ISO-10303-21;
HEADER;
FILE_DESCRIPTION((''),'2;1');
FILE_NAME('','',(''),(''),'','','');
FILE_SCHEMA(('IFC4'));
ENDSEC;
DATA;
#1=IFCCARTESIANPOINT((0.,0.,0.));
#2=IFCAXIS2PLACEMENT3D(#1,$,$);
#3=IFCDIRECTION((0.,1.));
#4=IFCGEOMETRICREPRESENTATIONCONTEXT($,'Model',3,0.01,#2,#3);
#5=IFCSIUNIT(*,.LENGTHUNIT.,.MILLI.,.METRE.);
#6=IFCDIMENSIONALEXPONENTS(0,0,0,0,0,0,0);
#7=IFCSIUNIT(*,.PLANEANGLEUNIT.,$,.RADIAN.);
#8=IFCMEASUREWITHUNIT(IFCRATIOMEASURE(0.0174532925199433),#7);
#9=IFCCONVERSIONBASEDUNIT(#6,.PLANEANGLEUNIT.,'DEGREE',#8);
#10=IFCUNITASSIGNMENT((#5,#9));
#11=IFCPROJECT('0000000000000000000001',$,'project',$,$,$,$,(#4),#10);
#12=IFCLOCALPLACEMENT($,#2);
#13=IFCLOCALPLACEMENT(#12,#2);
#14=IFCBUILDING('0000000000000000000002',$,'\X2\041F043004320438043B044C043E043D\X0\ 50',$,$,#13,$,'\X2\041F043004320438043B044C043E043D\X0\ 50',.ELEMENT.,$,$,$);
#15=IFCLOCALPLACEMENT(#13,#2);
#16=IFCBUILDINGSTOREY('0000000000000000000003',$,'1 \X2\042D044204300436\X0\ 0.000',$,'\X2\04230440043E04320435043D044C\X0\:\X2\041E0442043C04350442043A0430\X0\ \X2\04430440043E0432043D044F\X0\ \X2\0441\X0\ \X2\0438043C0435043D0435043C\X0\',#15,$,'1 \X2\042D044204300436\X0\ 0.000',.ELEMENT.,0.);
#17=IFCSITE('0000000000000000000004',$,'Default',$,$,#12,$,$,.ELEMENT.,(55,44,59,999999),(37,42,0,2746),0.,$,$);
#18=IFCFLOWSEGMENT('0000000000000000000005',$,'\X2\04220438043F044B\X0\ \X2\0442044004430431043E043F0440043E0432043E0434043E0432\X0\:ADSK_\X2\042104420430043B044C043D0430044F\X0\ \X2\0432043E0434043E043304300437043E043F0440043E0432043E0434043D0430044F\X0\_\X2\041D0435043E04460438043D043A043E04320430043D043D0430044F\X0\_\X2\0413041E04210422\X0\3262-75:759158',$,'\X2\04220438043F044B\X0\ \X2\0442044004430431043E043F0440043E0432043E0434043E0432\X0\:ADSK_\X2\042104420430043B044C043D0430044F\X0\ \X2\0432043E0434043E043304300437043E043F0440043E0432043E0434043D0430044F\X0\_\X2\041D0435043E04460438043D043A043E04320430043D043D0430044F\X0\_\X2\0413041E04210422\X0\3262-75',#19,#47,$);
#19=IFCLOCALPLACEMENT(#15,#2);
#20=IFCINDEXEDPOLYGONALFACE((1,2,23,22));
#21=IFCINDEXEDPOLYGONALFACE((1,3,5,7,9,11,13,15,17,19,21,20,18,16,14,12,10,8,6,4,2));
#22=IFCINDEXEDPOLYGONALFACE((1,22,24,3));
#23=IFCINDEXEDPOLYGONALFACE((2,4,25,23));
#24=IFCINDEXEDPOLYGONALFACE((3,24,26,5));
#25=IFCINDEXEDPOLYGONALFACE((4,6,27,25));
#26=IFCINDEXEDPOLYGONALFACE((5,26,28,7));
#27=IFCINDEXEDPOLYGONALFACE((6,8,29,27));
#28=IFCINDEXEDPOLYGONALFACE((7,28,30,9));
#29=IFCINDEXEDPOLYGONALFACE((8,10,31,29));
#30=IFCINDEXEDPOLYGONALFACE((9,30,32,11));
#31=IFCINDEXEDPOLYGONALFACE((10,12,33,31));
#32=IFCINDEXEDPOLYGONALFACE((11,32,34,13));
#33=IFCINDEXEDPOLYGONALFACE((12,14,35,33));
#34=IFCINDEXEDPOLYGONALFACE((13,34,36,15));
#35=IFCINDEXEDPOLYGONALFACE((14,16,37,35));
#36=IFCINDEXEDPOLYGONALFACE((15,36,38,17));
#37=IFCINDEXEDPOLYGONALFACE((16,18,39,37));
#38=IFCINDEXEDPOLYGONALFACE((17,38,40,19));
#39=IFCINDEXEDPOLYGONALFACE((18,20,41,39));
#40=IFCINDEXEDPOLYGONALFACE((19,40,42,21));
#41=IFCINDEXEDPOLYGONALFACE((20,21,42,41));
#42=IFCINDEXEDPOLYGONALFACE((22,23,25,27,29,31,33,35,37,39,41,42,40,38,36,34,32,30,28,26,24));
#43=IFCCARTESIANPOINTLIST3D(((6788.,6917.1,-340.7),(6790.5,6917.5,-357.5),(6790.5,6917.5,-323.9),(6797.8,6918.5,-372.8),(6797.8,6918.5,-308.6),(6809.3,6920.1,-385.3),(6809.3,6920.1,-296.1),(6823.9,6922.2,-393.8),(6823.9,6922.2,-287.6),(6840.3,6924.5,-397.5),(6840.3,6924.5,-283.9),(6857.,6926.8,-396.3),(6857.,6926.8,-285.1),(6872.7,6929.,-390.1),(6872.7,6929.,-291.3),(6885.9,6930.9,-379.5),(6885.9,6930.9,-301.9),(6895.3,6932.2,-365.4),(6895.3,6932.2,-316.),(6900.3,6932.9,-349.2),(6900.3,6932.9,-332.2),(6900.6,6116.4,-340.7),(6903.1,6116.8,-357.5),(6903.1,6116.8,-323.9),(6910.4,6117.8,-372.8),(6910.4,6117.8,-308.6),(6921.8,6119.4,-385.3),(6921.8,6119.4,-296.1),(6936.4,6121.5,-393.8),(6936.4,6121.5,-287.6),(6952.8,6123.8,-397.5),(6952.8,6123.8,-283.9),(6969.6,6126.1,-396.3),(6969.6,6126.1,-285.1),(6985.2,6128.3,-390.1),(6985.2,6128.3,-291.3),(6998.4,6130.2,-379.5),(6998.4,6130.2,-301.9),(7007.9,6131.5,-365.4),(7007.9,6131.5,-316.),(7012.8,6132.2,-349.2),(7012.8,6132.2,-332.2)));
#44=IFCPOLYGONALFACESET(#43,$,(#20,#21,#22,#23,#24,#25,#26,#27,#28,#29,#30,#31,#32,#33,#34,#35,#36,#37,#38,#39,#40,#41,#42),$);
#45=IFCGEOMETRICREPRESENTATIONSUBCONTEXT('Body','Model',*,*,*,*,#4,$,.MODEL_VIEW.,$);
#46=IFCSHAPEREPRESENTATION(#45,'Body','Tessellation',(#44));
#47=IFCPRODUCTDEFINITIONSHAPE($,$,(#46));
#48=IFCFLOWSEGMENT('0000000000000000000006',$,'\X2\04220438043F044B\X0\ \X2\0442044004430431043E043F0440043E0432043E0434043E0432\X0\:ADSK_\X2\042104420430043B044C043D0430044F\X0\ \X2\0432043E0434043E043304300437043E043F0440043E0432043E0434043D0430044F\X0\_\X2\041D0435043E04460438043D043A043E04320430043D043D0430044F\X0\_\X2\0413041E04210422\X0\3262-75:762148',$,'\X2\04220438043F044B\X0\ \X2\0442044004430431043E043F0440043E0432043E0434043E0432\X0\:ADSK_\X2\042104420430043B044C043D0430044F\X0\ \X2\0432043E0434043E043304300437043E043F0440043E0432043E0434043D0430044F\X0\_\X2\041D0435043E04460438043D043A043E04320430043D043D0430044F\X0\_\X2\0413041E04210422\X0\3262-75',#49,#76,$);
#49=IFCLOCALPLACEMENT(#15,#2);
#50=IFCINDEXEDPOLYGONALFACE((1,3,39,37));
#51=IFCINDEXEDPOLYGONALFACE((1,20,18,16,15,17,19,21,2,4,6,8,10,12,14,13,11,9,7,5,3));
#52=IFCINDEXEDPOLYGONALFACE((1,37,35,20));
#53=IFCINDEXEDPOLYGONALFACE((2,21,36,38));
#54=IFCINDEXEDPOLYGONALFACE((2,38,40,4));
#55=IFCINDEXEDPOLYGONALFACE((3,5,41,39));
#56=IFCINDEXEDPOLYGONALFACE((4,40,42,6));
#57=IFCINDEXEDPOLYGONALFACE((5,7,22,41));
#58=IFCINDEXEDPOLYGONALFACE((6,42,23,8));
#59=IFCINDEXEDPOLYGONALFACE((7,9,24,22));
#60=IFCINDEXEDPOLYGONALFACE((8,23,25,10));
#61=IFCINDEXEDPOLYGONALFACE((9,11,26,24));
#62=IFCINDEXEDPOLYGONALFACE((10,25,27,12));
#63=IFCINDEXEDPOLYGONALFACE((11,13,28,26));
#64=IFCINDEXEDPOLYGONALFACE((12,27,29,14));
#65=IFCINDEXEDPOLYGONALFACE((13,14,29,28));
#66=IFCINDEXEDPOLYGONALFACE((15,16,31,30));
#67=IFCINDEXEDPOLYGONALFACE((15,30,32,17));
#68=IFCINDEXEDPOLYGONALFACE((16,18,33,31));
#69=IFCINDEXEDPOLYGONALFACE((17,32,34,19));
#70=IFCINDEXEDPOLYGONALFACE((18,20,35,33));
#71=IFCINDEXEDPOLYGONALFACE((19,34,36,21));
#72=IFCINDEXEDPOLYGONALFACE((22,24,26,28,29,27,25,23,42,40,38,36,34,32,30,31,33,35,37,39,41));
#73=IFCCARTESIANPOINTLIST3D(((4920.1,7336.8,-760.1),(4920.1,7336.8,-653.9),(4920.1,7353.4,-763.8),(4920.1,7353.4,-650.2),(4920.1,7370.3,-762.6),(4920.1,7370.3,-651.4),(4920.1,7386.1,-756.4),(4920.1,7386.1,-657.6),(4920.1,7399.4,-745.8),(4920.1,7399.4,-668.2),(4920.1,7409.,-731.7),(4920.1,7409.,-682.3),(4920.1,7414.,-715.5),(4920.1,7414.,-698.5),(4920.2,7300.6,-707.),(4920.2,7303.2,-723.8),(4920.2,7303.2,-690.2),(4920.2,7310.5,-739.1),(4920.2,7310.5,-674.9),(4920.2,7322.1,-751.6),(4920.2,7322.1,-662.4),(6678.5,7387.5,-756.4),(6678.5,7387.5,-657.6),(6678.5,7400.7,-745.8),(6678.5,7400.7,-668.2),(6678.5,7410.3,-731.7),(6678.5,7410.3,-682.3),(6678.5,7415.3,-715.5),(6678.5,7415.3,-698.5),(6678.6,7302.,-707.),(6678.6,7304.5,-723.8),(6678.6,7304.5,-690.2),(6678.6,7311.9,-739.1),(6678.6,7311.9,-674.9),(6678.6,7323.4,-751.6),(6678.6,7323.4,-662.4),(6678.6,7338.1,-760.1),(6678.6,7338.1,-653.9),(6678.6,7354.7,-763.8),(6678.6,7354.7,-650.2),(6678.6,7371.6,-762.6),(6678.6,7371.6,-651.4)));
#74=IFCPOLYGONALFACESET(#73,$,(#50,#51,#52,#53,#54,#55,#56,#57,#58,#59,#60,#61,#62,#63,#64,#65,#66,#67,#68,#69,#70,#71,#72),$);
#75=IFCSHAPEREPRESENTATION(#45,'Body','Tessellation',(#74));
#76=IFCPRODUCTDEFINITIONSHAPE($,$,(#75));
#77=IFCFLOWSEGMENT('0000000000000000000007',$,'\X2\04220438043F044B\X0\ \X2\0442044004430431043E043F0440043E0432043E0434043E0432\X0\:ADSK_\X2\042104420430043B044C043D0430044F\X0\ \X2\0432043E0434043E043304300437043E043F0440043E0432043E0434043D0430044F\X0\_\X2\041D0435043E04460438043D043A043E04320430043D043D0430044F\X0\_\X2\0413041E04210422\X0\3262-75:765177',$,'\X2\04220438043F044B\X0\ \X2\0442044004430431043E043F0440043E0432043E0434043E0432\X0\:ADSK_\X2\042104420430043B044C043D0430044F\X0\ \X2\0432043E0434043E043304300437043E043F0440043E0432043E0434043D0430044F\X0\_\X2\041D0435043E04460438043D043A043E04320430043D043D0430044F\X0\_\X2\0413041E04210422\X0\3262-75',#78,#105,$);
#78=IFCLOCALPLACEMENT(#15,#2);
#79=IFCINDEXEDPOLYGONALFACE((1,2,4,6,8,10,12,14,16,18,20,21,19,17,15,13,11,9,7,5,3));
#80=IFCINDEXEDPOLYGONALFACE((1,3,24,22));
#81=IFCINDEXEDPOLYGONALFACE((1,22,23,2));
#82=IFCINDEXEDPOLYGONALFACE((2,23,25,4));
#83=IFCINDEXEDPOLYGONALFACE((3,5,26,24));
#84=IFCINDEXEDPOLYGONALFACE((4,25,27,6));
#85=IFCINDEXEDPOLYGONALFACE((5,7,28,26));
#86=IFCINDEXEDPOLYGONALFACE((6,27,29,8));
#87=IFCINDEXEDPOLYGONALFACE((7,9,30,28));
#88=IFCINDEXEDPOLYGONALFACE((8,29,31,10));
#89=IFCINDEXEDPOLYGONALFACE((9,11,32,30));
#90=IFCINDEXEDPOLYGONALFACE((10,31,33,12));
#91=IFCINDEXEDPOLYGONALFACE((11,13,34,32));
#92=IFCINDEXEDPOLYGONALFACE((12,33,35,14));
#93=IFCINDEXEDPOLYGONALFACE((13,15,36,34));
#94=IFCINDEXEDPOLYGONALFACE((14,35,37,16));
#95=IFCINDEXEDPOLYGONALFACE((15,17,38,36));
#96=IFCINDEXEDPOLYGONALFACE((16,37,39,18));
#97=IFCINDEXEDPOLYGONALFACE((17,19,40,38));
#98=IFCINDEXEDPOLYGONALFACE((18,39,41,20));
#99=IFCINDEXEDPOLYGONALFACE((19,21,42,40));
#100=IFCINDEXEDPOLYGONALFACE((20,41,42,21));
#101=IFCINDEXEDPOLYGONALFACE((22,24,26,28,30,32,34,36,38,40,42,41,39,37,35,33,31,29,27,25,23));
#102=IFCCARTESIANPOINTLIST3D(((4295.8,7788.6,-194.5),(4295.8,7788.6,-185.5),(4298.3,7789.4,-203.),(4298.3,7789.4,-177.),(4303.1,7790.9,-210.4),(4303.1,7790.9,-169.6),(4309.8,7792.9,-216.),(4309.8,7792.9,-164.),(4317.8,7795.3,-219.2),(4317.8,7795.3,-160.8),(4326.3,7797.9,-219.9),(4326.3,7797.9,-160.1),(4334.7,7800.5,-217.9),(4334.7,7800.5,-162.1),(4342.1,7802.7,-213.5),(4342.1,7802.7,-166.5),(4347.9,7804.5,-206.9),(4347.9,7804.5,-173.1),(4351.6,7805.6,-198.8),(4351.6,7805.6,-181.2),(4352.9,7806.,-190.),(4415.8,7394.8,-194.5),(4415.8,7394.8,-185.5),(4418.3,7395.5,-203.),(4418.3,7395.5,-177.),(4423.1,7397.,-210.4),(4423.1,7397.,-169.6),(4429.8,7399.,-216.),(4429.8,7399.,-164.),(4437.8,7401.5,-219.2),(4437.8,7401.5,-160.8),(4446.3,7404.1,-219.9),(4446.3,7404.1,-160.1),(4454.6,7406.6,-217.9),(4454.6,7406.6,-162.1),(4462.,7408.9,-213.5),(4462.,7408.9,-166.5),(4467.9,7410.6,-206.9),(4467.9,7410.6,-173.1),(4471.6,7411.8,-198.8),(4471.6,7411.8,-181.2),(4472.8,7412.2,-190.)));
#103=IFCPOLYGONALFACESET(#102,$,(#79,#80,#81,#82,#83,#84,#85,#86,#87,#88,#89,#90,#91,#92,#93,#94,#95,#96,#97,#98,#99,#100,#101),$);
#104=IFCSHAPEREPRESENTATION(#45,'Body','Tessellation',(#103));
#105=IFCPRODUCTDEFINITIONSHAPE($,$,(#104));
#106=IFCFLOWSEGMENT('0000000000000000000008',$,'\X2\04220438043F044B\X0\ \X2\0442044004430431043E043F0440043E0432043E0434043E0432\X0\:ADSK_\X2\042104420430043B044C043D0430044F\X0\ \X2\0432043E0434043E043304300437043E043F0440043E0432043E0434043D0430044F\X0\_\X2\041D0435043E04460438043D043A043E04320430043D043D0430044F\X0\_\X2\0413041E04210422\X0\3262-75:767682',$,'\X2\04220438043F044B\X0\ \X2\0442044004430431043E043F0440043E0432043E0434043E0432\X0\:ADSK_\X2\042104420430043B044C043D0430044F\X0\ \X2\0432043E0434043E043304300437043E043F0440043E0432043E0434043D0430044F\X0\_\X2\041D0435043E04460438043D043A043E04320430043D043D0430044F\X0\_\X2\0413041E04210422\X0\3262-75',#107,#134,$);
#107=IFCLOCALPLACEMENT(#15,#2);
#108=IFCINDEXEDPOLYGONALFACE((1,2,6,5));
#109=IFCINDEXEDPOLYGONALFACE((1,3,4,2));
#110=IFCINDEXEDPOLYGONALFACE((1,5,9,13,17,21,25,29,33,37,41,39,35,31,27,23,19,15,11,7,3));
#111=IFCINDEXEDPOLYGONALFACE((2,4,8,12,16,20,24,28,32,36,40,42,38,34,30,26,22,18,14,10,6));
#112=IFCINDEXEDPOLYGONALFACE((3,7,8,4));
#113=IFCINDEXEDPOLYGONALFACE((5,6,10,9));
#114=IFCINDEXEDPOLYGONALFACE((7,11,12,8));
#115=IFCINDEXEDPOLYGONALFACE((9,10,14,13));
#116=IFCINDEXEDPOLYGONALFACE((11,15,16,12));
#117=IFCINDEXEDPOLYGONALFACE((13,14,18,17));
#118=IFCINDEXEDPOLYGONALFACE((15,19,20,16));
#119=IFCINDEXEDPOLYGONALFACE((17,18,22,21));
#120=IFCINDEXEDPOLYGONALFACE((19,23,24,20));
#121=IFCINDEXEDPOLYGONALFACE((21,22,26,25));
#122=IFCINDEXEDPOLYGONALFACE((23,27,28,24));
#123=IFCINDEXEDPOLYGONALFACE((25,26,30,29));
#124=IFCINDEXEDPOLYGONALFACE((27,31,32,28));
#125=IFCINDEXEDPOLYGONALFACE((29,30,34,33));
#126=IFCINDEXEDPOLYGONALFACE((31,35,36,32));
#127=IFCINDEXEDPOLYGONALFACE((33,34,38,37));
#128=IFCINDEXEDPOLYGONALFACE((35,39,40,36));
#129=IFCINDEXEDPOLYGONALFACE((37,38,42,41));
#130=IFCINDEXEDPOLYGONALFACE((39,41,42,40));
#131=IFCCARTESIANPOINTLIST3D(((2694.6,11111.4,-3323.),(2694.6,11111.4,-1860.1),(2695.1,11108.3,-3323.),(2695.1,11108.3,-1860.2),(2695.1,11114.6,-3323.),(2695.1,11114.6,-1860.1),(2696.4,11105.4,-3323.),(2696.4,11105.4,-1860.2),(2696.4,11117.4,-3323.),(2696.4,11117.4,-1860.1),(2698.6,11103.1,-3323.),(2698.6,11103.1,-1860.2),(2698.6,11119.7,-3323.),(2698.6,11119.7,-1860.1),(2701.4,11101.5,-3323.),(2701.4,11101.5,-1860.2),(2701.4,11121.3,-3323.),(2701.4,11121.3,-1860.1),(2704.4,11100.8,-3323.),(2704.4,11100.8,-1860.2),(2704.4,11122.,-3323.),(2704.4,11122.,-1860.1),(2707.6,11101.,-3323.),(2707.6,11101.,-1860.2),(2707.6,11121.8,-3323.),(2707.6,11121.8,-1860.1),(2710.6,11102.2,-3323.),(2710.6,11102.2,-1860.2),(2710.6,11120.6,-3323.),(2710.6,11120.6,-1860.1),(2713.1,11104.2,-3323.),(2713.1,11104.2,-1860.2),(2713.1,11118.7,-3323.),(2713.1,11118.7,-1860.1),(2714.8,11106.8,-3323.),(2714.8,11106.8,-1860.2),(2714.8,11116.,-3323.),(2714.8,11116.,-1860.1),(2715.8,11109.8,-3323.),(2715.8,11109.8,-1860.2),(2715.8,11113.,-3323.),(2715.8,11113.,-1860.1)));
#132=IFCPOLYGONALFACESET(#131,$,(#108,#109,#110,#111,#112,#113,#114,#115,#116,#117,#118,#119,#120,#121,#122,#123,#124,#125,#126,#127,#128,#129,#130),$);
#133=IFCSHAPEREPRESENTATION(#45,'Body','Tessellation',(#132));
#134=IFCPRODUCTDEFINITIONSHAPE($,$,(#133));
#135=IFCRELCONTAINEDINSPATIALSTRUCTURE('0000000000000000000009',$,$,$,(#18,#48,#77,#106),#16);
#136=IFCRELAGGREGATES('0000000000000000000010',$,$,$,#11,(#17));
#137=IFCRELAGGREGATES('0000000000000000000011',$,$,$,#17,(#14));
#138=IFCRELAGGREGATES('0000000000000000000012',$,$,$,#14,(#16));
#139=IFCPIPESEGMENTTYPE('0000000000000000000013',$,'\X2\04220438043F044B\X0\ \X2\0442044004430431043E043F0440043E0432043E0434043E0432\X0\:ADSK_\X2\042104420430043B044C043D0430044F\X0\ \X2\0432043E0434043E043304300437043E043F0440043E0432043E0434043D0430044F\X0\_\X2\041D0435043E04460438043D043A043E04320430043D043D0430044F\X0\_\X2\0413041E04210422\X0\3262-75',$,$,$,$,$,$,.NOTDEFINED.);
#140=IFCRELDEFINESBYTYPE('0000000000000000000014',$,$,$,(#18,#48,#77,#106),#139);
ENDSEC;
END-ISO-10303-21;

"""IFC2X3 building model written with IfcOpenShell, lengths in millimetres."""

from ifc_helpers import new_model, entity, si_unit, converted_unit, direction, frame, frame_2d, origin, origin_2d_with_axis, place, context, subcontext, project, spatial, circle, extrude, type_object, element, save


model = new_model("IFC2X3")

# Units and contexts
model_context = context("Model", 3, precision=0.01, world=origin(), true_north=direction((0.0, 1.0)))
body_context = subcontext(model_context, "Body", "Model", "MODEL_VIEW")
ifc_project = project(units=[si_unit("LENGTHUNIT", "METRE", prefix="MILLI"), converted_unit("PLANEANGLEUNIT", "DEGREE", entity("IfcRatioMeasure", 0.0174532925199433), si_unit("PLANEANGLEUNIT", "RADIAN"), dimensions=[0, 0, 0, 0, 0, 0, 0])], contexts=[model_context])

# Site, building, storey
site_placement = place(None, origin())
site = spatial("IfcSite", under=ifc_project, at=site_placement, Name="Default", CompositionType="ELEMENT", RefLatitude=(55, 44, 59, 999999), RefLongitude=(37, 42, 0, 2746), RefElevation=0.0)
building_placement = place(site_placement, origin())
building = spatial("IfcBuilding", under=site, at=building_placement, Name="Павильон 50", LongName="Павильон 50", CompositionType="ELEMENT")
storey_placement = place(building_placement, origin())
storey = spatial("IfcBuildingStorey", under=building, at=storey_placement, Name="1 Этаж 0.000", ObjectType="Уровень:Отметка уровня с именем", LongName="1 Этаж 0.000", CompositionType="ELEMENT", Elevation=0.0)

# Flow segments
pipe_segment_type = type_object("IfcPipeSegmentType", Name="Типы трубопроводов:ADSK_Стальная водогазопроводная_Неоцинкованная_ГОСТ3262-75", PredefinedType="NOTDEFINED")
flow_segment_1_placement = place(storey_placement, frame((6786.4, 6114.8, -399.3)))
element("IfcFlowSegment", 1, at=flow_segment_1_placement, inside=storey, type_object=pipe_segment_type, Name="Типы трубопроводов:ADSK_Стальная водогазопроводная_Неоцинкованная_ГОСТ3262-75:759158", ObjectType="Типы трубопроводов:ADSK_Стальная водогазопроводная_Неоцинкованная_ГОСТ3262-75", context=body_context, shape_type="SweptSolid", body=[
    extrude(circle(Radius=57.0, at=frame_2d((0.0, 0.0), x_axis=(1.0, 0.0))), frame((58.0, 810.3, 58.6), z_axis=(0.139173, -0.990268, 0.0), x_axis=(-0.990268, -0.139173, 0.0)), (0.0, 0.0, 1.0), 808.6),
])
flow_segment_2_placement = place(storey_placement, frame((4920.1, 7299.0, -765.6)))
element("IfcFlowSegment", 2, at=flow_segment_2_placement, inside=storey, type_object=pipe_segment_type, Name="Типы трубопроводов:ADSK_Стальная водогазопроводная_Неоцинкованная_ГОСТ3262-75:762148", ObjectType="Типы трубопроводов:ADSK_Стальная водогазопроводная_Неоцинкованная_ГОСТ3262-75", context=body_context, shape_type="SweptSolid", body=[
    extrude(circle(Radius=57.0, at=origin_2d_with_axis()), frame((0.0, 58.6, 58.6), z_axis=(1.0, 0.000743, 0.0), x_axis=(0.000743, -1.0, 0.0)), (0.0, 0.0, 1.0), 1758.4),
])
flow_segment_3_placement = place(storey_placement, frame((4293.9, 7393.1, -221.6)))
element("IfcFlowSegment", 3, at=flow_segment_3_placement, inside=storey, type_object=pipe_segment_type, Name="Типы трубопроводов:ADSK_Стальная водогазопроводная_Неоцинкованная_ГОСТ3262-75:765177", ObjectType="Типы трубопроводов:ADSK_Стальная водогазопроводная_Неоцинкованная_ГОСТ3262-75", context=body_context, shape_type="SweptSolid", body=[
    extrude(circle(Radius=30.0, at=frame_2d((0.0, 0.0), x_axis=(1.0, 0.0))), frame((30.3, 404.2, 31.6), z_axis=(0.291394, -0.956603, 0.0), x_axis=(0.956603, 0.291394, 0.0)), (0.0, 0.0, 1.0), 411.7),
])
flow_segment_4_placement = place(storey_placement, frame((2693.0, 11099.2, -3323.0)))
element("IfcFlowSegment", 4, at=flow_segment_4_placement, inside=storey, type_object=pipe_segment_type, Name="Типы трубопроводов:ADSK_Стальная водогазопроводная_Неоцинкованная_ГОСТ3262-75:767682", ObjectType="Типы трубопроводов:ADSK_Стальная водогазопроводная_Неоцинкованная_ГОСТ3262-75", context=body_context, shape_type="SweptSolid", body=[
    extrude(circle(Radius=10.7, at=origin_2d_with_axis()), frame((12.2, 12.3, 0.0), z_axis=(0.0, -0.000008, 1.0), x_axis=(-1.0, 0.0, 0.0)), (0.0, 0.0, 1.0), 1462.9),
])

save(model, "model.ifc")
